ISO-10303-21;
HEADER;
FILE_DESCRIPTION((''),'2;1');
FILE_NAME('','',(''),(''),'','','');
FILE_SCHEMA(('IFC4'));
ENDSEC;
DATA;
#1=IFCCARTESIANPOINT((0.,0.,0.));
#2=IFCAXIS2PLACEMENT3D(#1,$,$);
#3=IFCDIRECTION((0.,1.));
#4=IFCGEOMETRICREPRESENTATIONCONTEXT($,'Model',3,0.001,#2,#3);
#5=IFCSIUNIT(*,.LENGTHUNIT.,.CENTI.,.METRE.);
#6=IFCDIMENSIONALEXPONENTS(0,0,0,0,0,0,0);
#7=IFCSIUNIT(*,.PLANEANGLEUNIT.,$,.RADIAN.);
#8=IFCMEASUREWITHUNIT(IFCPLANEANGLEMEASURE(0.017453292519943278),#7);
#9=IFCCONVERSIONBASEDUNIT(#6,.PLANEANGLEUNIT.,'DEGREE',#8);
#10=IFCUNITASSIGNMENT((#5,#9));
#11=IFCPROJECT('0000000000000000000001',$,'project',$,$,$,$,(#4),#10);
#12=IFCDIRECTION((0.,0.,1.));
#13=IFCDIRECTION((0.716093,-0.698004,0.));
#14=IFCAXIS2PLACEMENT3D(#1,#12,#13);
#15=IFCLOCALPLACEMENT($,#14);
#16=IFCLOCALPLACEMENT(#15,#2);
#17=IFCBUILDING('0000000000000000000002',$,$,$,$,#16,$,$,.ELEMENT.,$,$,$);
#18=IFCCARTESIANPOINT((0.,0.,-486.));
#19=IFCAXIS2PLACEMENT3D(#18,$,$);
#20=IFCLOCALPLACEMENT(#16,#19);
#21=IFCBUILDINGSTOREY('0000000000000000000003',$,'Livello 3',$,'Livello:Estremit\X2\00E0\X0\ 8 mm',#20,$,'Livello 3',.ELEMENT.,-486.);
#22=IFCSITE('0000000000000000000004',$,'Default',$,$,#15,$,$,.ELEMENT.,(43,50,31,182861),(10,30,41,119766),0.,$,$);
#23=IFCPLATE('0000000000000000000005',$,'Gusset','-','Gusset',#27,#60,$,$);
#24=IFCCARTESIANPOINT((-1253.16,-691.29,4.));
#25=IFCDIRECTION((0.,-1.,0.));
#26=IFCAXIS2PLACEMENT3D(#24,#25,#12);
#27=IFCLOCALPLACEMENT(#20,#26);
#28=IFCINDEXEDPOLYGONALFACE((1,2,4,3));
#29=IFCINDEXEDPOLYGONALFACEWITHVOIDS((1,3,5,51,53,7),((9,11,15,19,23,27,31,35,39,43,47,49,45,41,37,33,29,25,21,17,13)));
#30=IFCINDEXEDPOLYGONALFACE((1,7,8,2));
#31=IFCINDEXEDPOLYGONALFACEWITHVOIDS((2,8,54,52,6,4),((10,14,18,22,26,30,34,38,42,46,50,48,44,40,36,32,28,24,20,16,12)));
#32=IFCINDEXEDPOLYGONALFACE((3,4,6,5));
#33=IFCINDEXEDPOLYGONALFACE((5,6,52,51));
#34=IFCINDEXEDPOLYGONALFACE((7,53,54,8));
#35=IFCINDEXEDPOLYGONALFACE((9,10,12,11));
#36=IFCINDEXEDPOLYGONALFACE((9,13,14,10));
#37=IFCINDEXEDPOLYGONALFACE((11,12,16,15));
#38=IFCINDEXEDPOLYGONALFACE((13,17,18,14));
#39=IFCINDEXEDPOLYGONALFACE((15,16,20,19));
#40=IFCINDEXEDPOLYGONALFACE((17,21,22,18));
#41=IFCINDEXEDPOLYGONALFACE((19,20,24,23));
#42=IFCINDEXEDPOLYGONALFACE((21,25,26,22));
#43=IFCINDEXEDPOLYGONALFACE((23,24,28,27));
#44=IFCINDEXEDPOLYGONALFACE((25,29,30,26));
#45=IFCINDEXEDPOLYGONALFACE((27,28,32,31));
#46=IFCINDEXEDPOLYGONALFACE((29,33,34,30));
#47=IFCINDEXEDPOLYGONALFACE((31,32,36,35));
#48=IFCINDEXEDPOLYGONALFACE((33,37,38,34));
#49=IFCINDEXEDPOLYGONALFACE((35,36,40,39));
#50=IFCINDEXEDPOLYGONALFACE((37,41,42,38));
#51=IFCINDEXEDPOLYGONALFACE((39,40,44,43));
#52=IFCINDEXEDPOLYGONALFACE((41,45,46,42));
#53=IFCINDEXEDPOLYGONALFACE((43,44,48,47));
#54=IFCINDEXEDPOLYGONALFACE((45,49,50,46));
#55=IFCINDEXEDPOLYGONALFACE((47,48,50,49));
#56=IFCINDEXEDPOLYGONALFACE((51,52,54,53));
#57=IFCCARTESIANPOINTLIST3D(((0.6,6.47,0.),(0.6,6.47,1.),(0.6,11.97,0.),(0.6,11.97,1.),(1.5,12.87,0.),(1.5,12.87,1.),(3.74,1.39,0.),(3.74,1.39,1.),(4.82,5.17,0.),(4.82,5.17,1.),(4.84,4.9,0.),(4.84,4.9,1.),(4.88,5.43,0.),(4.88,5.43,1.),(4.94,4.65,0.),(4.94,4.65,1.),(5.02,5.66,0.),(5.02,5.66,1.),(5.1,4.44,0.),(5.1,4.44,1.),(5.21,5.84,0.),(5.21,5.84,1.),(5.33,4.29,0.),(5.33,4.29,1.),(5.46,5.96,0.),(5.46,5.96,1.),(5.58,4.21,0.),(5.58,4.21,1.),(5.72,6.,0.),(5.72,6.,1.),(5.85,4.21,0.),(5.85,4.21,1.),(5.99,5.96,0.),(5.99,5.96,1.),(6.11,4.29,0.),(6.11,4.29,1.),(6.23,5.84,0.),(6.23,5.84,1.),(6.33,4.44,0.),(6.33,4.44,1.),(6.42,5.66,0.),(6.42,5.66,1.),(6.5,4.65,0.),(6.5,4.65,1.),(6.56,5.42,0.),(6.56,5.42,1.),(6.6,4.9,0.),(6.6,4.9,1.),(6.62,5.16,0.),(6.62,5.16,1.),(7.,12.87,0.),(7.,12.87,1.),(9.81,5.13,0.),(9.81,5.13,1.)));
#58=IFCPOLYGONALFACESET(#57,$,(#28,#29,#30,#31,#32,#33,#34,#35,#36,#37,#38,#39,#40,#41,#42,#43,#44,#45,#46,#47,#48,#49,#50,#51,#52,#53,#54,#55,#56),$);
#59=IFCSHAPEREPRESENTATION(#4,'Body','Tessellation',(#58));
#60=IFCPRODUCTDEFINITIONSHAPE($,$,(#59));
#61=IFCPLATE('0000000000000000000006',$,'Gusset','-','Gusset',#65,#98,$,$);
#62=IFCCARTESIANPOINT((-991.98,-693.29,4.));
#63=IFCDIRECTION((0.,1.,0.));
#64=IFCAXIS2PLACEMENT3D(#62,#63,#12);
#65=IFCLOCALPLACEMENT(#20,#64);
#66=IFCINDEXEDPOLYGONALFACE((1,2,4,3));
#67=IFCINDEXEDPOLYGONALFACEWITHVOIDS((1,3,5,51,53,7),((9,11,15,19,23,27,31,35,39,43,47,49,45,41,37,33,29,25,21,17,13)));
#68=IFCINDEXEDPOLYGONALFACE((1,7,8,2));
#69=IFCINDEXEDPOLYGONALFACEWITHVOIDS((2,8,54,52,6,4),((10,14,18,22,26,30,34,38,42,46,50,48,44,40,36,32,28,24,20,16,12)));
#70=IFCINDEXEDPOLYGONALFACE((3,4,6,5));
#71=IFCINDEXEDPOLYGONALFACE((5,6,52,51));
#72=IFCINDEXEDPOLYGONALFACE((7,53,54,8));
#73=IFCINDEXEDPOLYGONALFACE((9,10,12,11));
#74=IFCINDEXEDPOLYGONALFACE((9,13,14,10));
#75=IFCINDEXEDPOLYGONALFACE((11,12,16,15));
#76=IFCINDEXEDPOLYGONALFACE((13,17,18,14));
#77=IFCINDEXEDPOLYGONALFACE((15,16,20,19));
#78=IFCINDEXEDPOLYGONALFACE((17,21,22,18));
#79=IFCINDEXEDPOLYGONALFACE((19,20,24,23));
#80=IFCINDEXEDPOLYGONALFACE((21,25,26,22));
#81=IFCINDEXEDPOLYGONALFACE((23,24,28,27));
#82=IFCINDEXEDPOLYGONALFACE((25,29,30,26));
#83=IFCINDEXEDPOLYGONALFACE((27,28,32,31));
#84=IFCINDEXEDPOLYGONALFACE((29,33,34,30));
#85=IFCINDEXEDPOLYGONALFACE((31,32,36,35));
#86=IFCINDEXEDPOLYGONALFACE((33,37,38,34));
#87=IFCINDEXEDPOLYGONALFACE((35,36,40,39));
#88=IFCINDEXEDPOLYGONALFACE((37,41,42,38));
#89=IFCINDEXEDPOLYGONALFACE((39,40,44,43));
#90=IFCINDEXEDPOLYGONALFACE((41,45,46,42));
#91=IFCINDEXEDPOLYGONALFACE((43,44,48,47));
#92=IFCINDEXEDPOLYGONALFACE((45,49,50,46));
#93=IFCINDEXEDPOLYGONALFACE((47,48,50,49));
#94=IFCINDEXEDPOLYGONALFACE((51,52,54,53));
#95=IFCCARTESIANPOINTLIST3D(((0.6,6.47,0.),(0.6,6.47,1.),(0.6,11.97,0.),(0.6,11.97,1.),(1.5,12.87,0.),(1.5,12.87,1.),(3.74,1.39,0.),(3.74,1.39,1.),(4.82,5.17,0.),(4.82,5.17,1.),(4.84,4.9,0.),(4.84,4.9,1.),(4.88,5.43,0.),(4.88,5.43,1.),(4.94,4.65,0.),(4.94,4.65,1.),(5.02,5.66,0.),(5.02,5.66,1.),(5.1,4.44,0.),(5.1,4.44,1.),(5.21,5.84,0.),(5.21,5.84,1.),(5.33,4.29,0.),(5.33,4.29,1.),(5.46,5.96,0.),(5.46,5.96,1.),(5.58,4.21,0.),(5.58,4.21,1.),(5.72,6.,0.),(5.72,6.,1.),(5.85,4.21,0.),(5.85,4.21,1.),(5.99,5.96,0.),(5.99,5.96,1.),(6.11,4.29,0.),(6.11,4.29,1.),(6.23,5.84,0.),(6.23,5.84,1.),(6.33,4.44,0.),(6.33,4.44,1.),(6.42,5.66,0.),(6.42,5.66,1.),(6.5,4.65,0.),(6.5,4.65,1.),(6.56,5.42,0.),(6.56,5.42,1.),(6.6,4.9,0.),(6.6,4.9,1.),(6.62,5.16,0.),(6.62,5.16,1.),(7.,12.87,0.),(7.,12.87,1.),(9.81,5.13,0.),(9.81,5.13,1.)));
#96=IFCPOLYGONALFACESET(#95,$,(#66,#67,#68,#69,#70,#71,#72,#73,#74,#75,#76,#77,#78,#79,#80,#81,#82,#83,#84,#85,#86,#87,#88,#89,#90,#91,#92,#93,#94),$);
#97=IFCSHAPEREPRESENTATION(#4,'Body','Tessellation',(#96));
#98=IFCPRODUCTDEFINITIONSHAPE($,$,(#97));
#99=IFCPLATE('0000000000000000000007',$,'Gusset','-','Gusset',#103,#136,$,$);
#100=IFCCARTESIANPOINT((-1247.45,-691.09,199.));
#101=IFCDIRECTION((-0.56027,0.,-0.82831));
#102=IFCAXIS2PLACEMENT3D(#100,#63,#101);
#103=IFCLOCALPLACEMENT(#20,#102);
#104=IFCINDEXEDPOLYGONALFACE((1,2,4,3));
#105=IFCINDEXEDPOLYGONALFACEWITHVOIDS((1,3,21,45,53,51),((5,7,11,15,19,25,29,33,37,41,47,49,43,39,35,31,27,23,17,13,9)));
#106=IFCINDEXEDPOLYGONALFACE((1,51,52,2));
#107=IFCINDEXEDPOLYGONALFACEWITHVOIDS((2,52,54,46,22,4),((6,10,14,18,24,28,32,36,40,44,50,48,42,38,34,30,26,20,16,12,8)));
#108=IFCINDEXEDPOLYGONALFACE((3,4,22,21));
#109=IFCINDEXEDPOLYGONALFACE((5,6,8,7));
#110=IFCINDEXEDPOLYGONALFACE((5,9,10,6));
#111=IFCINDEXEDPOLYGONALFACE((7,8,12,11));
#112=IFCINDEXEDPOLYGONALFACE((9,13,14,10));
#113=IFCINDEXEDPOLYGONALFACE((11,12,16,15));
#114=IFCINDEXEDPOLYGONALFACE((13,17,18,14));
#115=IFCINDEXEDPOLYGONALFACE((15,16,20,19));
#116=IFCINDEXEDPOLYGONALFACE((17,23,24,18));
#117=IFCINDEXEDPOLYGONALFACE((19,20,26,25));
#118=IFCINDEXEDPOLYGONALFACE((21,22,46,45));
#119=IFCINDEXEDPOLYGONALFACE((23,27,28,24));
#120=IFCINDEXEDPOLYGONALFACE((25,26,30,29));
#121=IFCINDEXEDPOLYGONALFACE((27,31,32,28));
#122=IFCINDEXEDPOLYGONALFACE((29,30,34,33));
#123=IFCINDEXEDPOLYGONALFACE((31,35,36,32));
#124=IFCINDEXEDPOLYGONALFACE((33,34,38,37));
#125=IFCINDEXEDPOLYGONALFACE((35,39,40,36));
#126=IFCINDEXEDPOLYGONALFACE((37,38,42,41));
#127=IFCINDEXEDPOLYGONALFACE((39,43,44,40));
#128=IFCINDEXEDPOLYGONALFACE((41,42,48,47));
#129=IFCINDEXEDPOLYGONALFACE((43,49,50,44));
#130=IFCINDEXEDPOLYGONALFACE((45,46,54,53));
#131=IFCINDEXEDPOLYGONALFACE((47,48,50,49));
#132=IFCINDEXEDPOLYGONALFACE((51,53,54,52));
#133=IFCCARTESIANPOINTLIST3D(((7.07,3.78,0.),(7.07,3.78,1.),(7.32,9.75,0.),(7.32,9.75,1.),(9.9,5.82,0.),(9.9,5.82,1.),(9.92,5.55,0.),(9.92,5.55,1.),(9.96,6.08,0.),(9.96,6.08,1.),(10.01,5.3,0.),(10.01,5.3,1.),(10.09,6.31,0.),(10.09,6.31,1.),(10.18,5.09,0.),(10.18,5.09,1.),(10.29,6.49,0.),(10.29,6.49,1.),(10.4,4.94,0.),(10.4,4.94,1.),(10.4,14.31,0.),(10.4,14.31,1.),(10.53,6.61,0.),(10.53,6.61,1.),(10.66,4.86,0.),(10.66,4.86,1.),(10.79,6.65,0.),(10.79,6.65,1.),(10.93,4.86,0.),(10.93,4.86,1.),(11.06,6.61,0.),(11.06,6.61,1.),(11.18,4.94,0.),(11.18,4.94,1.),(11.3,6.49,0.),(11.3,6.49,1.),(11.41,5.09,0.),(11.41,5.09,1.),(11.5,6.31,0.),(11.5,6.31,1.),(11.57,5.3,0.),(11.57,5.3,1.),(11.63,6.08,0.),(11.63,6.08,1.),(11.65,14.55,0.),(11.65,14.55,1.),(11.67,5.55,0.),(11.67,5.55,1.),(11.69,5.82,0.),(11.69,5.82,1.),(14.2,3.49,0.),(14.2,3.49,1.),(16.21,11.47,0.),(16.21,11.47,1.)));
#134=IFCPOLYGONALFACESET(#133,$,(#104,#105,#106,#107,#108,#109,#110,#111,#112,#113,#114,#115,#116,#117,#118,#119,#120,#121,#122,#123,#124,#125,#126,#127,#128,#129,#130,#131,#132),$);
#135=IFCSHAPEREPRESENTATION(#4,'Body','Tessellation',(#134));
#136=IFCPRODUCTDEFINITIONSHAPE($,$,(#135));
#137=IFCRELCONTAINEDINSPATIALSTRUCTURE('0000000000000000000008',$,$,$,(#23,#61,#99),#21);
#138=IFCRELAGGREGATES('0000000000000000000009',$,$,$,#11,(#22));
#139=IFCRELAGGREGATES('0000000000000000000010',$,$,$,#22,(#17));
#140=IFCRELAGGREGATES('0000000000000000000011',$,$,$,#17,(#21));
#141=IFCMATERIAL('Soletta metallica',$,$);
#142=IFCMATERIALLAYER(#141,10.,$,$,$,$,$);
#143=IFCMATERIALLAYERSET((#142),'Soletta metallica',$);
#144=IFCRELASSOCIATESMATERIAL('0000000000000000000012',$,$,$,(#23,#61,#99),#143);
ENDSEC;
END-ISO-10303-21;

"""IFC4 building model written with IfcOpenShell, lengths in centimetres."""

from ifc_helpers import new_model, entity, si_unit, converted_unit, point, direction, frame, frame_2d, origin, origin_with_axes, origin_2d_with_axis, place, context, project, spatial, polyline, circle_curve, line_curve, trimmed, segment, composite_curve, circle, outline, extrude, material, layer, layer_set, element, save


model = new_model("IFC4")

# Units and contexts
model_context = context("Model", 3, precision=0.001, world=origin(), true_north=direction((0.0, 1.0)))
ifc_project = project(units=[si_unit("LENGTHUNIT", "METRE", prefix="CENTI"), converted_unit("PLANEANGLEUNIT", "DEGREE", entity("IfcPlaneAngleMeasure", 0.017453292519943278), si_unit("PLANEANGLEUNIT", "RADIAN"), dimensions=[0, 0, 0, 0, 0, 0, 0])], contexts=[model_context])

# Site, building, storey
site_placement = place(None, frame((0.0, 0.0, 0.0), z_axis=(0.0, 0.0, 1.0), x_axis=(0.716093, -0.698004, 0.0)))
site = spatial("IfcSite", under=ifc_project, at=site_placement, Name="Default", CompositionType="ELEMENT", RefLatitude=(43, 50, 31, 182861), RefLongitude=(10, 30, 41, 119766), RefElevation=0.0)
building_placement = place(site_placement, origin())
building = spatial("IfcBuilding", under=site, at=building_placement, CompositionType="ELEMENT")
storey_placement = place(building_placement, frame((0.0, 0.0, -486.0)))
storey = spatial("IfcBuildingStorey", under=building, at=storey_placement, Name="Livello 3", ObjectType="Livello:Estremità 8 mm", LongName="Livello 3", CompositionType="ELEMENT", Elevation=-486.0)

# Plates, openings
ifc_material_1 = material(Name="Soletta metallica")
ifc_layer_1 = layer(ifc_material_1, 10.0)
ifc_layer_set_1 = layer_set([ifc_layer_1], Name="Soletta metallica")
plate_1_placement = place(storey_placement, frame((-1253.16, -691.29, 4.0), z_axis=(0.0, -1.0, 0.0), x_axis=(0.0, 0.0, 1.0)))
plate_1 = element("IfcPlate", 1, at=plate_1_placement, inside=storey, material=ifc_layer_set_1, Name="Gusset", Description="-", ObjectType="Gusset", context=model_context, shape_type="SweptSolid", body=[
    extrude(outline(polyline([(0.6, 6.47), (3.74, 1.39), (9.81, 5.13), (7.0, 12.87), (0.6, 12.87), (0.6, 6.47)])), origin_with_axes(), (0.0, 0.0, 1.0), 1.0),
])
opening_1_placement = place(plate_1_placement, frame((0.0, 0.0, 0.0), z_axis=(0.0, 0.0, 1.0), x_axis=(1.0, 0.0, 0.0)))
element("IfcOpeningElement", 2, at=opening_1_placement, cuts=plate_1, ObjectType="Opening", context=model_context, shape_type="SweptSolid", body=[
    extrude(outline(composite_curve([segment(trimmed(line_curve((0.6, 12.87), (0.0, -1.0), 0.9), [point((0.6, 12.87))], [point((0.6, 11.97))], True, "CARTESIAN"), True, "CONTINUOUS"), segment(trimmed(circle_curve(frame_2d((1.5, 11.97), x_axis=(-1.0, 0.0)), 0.9), [point((0.6, 11.97))], [point((1.5, 12.87))], False, "CARTESIAN"), True, "CONTINUOUS"), segment(trimmed(line_curve((1.5, 12.87), (-1.0, 0.0), 0.9), [point((1.5, 12.87))], [point((0.6, 12.87))], True, "CARTESIAN"), True, "CONTINUOUS")], self_intersect="UNKNOWN")), origin(), (0.0, 0.0, 1.0), 1.0),
])
opening_2_placement = place(plate_1_placement, frame((5.72, 5.1, 1.05), z_axis=(0.0, 0.0, -1.0), x_axis=(-0.56027, 0.82831, 0.0)))
element("IfcOpeningElement", 3, at=opening_2_placement, cuts=plate_1, ObjectType="Opening", context=model_context, shape_type="SweptSolid", body=[
    extrude(circle(Radius=0.9, at=origin_2d_with_axis()), origin(), (0.0, 0.0, 1.0), 1.1),
])
plate_2_placement = place(storey_placement, frame((-991.98, -693.29, 4.0), z_axis=(0.0, 1.0, 0.0), x_axis=(0.0, 0.0, 1.0)))
plate_2 = element("IfcPlate", 4, at=plate_2_placement, inside=storey, material=ifc_layer_set_1, Name="Gusset", Description="-", ObjectType="Gusset", context=model_context, shape_type="SweptSolid", body=[
    extrude(outline(polyline([(0.6, 6.47), (3.74, 1.39), (9.81, 5.13), (7.0, 12.87), (0.6, 12.87), (0.6, 6.47)])), origin_with_axes(), (0.0, 0.0, 1.0), 1.0),
])
opening_3_placement = place(plate_2_placement, frame((0.0, 0.0, 0.0), z_axis=(0.0, 0.0, 1.0), x_axis=(1.0, 0.0, 0.0)))
element("IfcOpeningElement", 5, at=opening_3_placement, cuts=plate_2, ObjectType="Opening", context=model_context, shape_type="SweptSolid", body=[
    extrude(outline(composite_curve([segment(trimmed(line_curve((0.6, 12.87), (0.0, -1.0), 0.9), [point((0.6, 12.87))], [point((0.6, 11.97))], True, "CARTESIAN"), True, "CONTINUOUS"), segment(trimmed(circle_curve(frame_2d((1.5, 11.97), x_axis=(-1.0, 0.0)), 0.9), [point((0.6, 11.97))], [point((1.5, 12.87))], False, "CARTESIAN"), True, "CONTINUOUS"), segment(trimmed(line_curve((1.5, 12.87), (-1.0, 0.0), 0.9), [point((1.5, 12.87))], [point((0.6, 12.87))], True, "CARTESIAN"), True, "CONTINUOUS")], self_intersect="UNKNOWN")), origin(), (0.0, 0.0, 1.0), 1.0),
])
opening_4_placement = place(plate_2_placement, frame((5.72, 5.1, 1.05), z_axis=(0.0, 0.0, -1.0), x_axis=(-0.56027, 0.82831, 0.0)))
element("IfcOpeningElement", 6, at=opening_4_placement, cuts=plate_2, ObjectType="Opening", context=model_context, shape_type="SweptSolid", body=[
    extrude(circle(Radius=0.9, at=origin_2d_with_axis()), origin(), (0.0, 0.0, 1.0), 1.1),
])
plate_3_placement = place(storey_placement, frame((-1247.45, -691.09, 199.0), z_axis=(0.0, 1.0, 0.0), x_axis=(-0.56027, 0.0, -0.82831)))
plate_3 = element("IfcPlate", 7, at=plate_3_placement, inside=storey, material=ifc_layer_set_1, Name="Gusset", Description="-", ObjectType="Gusset", context=model_context, shape_type="SweptSolid", body=[
    extrude(outline(polyline([(10.91, 15.05), (7.32, 9.75), (7.07, 3.78), (14.2, 3.49), (16.21, 11.47), (10.91, 15.05)])), origin_with_axes(), (0.0, 0.0, 1.0), 1.0),
])
opening_5_placement = place(plate_3_placement, frame((0.0, 0.0, 0.0), z_axis=(0.0, 0.0, 1.0), x_axis=(1.0, 0.0, 0.0)))
element("IfcOpeningElement", 8, at=opening_5_placement, cuts=plate_3, ObjectType="Opening", context=model_context, shape_type="SweptSolid", body=[
    extrude(outline(composite_curve([segment(trimmed(line_curve((10.91, 15.05), (-0.56027, -0.82831), 0.9), [point((10.91, 15.05))], [point((10.4, 14.31))], True, "CARTESIAN"), True, "CONTINUOUS"), segment(trimmed(circle_curve(frame_2d((11.15, 13.8), x_axis=(-1.0, 0.0)), 0.9), [point((10.4, 14.31))], [point((11.65, 14.55))], False, "CARTESIAN"), True, "CONTINUOUS"), segment(trimmed(line_curve((11.65, 14.55), (-0.82831, 0.56027), 0.9), [point((11.65, 14.55))], [point((10.91, 15.05))], True, "CARTESIAN"), True, "CONTINUOUS")], self_intersect="UNKNOWN")), origin(), (0.0, 0.0, 1.0), 1.0),
])
opening_6_placement = place(plate_3_placement, frame((10.79, 5.75, -0.05), z_axis=(0.0, 0.0, 1.0), x_axis=(0.0, 1.0, 0.0)))
element("IfcOpeningElement", 9, at=opening_6_placement, cuts=plate_3, ObjectType="Opening", context=model_context, shape_type="SweptSolid", body=[
    extrude(circle(Radius=0.9, at=origin_2d_with_axis()), origin(), (0.0, 0.0, 1.0), 1.1),
])

save(model, "model.ifc")
